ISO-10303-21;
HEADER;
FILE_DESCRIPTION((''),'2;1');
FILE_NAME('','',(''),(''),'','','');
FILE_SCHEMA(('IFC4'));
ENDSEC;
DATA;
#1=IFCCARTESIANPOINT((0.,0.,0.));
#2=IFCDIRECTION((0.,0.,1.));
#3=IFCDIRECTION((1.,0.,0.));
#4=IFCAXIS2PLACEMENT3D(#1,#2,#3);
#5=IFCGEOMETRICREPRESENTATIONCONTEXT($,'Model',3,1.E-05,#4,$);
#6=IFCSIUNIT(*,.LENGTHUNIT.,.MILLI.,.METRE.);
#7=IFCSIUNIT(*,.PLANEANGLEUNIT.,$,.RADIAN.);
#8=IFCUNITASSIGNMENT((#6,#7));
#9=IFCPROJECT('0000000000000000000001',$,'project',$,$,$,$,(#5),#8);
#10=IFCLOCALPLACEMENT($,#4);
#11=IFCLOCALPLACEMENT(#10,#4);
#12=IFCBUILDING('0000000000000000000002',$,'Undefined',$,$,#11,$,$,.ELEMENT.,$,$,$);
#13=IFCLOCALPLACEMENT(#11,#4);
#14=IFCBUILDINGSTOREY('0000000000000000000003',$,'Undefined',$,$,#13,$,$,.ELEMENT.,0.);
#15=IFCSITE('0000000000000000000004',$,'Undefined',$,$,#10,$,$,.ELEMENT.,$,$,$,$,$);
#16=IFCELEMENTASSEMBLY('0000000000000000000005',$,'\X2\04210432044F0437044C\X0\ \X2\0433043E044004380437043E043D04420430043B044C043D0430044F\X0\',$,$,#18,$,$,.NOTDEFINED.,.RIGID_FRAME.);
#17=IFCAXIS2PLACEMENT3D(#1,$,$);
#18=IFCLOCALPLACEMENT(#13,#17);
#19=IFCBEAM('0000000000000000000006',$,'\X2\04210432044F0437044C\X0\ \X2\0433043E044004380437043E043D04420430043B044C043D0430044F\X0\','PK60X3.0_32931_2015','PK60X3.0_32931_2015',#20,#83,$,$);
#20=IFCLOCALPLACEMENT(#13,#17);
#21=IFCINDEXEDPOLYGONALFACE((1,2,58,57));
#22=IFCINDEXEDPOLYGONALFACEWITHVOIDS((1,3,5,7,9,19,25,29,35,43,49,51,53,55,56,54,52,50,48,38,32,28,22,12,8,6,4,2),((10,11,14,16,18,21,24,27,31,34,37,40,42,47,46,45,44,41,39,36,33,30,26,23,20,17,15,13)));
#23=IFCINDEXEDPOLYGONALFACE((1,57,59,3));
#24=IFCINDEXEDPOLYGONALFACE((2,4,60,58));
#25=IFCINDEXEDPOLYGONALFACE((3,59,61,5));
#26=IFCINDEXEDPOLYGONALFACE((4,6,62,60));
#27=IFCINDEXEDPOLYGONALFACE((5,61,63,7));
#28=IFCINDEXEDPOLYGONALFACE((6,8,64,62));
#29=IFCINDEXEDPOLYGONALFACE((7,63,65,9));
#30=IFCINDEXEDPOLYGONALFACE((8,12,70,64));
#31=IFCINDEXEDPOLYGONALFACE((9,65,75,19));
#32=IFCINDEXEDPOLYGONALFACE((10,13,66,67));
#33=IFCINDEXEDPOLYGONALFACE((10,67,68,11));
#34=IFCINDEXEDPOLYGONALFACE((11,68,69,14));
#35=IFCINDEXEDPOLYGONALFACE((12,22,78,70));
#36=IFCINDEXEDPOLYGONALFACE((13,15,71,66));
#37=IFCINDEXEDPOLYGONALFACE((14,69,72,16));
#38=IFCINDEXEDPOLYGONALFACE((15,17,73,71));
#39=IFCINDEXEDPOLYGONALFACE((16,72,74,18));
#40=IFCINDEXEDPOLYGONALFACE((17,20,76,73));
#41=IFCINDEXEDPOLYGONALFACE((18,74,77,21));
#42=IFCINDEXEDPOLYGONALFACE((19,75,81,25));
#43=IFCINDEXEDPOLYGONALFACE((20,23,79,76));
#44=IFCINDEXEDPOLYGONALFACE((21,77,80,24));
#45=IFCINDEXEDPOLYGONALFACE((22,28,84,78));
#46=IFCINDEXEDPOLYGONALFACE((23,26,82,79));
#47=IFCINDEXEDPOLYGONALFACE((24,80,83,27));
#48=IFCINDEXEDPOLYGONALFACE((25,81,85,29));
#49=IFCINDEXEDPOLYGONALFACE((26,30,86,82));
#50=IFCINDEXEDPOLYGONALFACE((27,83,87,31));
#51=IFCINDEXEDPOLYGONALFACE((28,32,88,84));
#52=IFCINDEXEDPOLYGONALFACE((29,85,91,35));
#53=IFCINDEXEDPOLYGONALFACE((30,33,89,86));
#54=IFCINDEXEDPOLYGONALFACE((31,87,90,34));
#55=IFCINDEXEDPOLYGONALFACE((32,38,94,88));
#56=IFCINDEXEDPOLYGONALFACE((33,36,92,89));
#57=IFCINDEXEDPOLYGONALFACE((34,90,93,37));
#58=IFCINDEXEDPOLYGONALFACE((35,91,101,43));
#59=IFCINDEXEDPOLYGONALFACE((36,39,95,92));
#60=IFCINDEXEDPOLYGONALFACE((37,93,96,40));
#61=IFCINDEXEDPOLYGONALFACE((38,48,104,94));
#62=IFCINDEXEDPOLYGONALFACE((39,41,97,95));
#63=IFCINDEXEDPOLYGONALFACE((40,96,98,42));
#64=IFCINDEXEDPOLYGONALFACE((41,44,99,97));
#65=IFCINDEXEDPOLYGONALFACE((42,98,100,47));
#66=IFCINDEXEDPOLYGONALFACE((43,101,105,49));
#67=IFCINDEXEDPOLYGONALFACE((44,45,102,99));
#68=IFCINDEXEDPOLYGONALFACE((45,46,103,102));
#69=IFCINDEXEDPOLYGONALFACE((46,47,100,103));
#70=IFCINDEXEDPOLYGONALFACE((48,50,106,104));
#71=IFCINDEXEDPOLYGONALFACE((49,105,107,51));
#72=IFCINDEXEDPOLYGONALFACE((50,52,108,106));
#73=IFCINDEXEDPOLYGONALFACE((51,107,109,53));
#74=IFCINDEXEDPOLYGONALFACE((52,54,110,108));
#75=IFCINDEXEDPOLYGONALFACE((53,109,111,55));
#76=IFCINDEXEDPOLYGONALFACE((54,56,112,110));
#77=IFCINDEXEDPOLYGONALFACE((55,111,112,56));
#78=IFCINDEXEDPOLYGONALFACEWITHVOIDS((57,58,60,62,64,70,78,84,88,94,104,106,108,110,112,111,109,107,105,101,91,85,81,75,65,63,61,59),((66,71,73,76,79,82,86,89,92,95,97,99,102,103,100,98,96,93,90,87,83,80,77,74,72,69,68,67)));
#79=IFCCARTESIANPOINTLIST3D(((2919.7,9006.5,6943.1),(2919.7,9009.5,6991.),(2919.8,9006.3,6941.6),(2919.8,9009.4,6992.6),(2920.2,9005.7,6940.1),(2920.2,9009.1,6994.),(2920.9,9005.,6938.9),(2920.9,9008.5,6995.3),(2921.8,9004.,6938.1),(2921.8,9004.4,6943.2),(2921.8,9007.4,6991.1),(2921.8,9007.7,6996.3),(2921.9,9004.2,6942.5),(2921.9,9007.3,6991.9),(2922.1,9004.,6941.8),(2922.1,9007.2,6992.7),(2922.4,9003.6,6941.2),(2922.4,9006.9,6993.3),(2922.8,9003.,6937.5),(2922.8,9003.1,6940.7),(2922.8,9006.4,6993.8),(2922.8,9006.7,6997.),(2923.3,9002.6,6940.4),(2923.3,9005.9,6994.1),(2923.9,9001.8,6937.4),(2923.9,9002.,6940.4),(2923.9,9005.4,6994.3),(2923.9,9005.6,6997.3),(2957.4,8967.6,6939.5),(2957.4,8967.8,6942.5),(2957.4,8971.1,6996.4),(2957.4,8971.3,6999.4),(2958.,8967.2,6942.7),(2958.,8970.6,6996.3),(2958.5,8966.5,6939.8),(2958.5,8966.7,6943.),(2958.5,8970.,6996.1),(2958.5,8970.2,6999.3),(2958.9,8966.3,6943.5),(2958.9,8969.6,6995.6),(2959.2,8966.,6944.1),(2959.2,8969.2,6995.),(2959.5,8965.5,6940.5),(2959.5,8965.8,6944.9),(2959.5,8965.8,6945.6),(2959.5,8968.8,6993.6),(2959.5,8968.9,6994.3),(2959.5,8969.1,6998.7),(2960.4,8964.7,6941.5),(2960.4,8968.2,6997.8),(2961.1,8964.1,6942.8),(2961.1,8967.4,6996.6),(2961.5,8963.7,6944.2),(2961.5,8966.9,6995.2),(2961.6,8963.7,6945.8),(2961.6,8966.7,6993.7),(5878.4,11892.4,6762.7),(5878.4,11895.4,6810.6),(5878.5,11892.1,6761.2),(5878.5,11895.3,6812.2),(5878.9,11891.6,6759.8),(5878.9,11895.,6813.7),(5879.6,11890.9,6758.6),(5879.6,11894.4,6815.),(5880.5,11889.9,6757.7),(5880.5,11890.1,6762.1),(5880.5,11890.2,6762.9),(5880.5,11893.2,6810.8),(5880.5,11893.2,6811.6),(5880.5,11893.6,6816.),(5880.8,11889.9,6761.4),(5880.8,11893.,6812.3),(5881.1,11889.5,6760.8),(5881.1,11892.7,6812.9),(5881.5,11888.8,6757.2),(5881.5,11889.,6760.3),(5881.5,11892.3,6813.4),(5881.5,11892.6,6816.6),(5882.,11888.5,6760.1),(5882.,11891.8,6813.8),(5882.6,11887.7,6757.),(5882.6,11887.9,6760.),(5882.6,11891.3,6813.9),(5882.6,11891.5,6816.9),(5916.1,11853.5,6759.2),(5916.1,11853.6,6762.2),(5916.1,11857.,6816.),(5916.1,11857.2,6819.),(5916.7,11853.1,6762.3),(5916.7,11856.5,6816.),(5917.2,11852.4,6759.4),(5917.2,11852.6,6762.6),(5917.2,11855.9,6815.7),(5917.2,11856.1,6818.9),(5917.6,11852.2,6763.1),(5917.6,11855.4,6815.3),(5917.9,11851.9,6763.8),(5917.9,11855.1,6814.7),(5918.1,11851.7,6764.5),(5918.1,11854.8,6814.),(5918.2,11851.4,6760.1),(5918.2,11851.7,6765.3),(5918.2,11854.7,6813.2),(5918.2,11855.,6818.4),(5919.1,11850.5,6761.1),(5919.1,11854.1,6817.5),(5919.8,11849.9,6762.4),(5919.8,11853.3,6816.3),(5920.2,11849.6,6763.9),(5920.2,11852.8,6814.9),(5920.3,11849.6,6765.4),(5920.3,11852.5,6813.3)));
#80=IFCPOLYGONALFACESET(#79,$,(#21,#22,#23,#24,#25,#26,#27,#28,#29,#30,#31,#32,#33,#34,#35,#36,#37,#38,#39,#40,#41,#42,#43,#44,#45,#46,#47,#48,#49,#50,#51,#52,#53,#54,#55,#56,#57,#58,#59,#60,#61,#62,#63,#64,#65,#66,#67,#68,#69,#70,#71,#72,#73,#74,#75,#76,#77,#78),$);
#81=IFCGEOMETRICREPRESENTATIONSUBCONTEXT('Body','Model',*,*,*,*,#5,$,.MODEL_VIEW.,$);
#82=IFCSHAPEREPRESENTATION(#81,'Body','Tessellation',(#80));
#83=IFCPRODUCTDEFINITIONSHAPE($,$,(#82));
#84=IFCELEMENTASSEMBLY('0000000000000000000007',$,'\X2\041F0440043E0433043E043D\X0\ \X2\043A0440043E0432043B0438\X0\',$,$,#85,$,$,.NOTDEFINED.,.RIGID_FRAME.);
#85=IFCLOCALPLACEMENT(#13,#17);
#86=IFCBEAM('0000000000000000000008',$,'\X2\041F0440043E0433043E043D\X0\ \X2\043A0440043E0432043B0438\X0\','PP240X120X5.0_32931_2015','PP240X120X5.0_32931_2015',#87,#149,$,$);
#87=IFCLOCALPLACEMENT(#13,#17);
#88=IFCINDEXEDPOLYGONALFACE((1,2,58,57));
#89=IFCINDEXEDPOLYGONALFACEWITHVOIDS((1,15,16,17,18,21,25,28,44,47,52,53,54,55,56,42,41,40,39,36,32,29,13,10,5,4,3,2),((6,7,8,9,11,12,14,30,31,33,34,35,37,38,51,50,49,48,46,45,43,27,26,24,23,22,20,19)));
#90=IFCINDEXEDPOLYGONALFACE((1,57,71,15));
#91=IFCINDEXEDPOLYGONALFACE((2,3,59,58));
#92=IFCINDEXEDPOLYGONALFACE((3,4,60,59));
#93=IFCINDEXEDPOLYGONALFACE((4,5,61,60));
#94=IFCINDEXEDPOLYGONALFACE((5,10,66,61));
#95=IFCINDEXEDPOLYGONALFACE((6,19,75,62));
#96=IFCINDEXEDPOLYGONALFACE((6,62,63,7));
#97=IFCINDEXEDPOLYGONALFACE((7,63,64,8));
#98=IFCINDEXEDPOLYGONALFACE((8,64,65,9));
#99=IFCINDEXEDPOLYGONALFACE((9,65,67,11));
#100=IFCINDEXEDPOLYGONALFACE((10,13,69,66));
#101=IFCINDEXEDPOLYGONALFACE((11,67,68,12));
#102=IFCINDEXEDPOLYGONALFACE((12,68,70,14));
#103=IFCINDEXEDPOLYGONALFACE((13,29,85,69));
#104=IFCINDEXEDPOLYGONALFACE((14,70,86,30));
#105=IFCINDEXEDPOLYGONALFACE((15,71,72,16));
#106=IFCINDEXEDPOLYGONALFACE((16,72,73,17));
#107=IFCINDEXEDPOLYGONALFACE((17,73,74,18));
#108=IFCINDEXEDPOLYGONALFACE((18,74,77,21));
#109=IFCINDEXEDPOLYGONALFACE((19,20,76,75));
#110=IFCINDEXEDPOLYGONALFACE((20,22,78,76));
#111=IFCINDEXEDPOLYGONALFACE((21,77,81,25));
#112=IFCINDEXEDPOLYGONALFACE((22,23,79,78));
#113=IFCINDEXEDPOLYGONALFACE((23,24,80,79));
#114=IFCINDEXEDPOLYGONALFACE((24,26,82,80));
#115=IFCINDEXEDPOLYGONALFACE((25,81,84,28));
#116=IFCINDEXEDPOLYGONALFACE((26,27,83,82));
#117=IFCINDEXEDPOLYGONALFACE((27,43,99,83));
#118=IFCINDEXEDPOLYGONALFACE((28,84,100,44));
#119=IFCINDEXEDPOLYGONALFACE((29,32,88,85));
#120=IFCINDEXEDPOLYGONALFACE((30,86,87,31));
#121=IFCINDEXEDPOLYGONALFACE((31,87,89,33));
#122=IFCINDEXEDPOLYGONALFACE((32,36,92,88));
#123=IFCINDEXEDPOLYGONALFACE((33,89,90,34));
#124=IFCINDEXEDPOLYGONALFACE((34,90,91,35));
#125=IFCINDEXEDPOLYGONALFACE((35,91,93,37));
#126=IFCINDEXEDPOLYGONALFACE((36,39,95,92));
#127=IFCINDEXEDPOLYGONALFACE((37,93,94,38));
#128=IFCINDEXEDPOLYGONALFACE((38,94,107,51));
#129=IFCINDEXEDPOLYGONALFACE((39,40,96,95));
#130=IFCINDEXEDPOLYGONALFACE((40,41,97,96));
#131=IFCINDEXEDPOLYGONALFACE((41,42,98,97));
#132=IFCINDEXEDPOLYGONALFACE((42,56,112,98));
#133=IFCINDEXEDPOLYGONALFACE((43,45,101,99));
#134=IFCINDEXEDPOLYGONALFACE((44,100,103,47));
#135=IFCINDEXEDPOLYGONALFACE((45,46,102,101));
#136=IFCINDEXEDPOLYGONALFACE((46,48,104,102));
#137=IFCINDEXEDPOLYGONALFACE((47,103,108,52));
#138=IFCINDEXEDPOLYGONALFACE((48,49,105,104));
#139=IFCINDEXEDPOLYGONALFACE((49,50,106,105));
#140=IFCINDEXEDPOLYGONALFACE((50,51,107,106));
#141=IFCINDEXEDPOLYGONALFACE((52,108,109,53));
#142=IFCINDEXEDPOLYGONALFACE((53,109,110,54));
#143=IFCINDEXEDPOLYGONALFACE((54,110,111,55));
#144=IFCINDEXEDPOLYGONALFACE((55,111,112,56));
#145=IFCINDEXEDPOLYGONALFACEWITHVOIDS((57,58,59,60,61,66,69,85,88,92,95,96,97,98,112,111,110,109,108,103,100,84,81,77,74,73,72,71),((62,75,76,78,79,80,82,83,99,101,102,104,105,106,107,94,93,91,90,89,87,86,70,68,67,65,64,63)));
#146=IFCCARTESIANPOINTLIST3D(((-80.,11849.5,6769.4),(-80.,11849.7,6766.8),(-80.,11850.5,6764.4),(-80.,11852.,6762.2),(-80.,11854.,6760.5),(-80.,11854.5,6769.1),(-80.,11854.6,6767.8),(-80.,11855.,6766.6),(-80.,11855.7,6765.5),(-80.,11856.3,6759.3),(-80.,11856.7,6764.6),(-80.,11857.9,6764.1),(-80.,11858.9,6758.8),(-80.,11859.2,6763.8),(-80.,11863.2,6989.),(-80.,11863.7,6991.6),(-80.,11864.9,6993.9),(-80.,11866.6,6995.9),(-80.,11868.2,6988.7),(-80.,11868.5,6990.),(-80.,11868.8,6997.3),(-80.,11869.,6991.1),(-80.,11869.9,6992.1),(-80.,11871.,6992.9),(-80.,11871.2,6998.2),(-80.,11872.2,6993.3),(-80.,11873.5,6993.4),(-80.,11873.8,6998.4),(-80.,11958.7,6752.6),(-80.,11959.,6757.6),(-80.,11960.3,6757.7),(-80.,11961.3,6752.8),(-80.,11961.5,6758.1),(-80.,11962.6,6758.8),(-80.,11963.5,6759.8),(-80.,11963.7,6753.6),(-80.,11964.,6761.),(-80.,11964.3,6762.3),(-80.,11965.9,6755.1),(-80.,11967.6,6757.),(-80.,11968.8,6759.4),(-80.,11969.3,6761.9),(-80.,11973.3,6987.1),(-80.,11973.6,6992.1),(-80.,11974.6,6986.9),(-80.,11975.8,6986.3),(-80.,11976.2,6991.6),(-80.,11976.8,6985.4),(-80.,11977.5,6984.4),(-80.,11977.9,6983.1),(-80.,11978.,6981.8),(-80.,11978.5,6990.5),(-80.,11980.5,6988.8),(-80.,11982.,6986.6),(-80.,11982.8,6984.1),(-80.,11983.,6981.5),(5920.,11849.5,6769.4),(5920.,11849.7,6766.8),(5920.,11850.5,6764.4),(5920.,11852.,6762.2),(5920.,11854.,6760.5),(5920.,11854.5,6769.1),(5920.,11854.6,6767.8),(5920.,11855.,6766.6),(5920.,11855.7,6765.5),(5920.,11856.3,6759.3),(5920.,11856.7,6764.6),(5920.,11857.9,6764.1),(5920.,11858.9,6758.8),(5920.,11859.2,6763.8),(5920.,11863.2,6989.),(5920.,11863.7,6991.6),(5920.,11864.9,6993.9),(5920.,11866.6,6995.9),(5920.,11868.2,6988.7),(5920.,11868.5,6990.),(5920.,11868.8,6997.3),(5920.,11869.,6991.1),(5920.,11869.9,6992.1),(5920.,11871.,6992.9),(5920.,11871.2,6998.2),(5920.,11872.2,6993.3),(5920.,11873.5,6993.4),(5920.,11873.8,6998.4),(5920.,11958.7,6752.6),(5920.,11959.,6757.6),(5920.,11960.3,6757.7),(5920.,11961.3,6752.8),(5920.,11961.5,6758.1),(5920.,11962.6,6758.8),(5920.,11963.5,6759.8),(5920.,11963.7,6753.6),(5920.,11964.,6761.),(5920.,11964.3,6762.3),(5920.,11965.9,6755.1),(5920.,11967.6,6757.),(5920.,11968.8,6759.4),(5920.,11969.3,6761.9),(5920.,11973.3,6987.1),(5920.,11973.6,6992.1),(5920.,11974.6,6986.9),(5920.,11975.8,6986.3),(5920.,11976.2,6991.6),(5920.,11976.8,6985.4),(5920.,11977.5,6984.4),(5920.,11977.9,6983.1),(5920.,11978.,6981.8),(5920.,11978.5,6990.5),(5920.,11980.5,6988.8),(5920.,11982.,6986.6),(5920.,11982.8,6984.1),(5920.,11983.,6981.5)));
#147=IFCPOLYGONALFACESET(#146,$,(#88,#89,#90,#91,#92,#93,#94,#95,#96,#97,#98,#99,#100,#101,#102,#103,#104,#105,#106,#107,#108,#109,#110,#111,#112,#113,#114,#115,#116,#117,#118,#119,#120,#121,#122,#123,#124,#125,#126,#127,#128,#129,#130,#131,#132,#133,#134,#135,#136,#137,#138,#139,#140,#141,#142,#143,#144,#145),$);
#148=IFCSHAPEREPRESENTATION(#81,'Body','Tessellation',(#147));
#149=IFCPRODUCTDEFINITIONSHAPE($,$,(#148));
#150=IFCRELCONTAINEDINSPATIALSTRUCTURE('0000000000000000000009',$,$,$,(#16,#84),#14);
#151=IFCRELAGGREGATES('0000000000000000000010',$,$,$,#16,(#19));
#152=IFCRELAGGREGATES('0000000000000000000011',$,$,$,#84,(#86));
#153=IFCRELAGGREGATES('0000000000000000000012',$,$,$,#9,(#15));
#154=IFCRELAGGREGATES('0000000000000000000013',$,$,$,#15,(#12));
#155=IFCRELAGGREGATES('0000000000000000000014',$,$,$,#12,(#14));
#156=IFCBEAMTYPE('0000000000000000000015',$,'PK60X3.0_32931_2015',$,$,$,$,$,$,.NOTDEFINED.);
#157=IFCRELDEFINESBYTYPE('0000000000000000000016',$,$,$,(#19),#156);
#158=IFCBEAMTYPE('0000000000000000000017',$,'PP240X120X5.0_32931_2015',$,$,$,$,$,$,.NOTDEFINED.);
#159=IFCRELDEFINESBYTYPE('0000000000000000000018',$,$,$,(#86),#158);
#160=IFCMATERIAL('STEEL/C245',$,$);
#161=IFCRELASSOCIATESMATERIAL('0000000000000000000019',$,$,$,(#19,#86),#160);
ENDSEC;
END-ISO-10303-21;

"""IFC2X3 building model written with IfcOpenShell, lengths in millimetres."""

from ifc_helpers import new_model, si_unit, frame, origin_with_axes, origin_2d_with_axis, place, context, subcontext, project, spatial, hollow_rectangle, extrude, material, type_object, element, aggregate, save


model = new_model("IFC2X3")

# Units and contexts
model_context = context("Model", 3, precision=1e-05, world=origin_with_axes())
body_context = subcontext(model_context, "Body", "Model", "MODEL_VIEW")
ifc_project = project(units=[si_unit("LENGTHUNIT", "METRE", prefix="MILLI"), si_unit("PLANEANGLEUNIT", "RADIAN")], contexts=[model_context])

# Site, building, storey
site_placement = place(None, origin_with_axes())
site = spatial("IfcSite", under=ifc_project, at=site_placement, Name="Undefined", CompositionType="ELEMENT")
building_placement = place(site_placement, origin_with_axes())
building = spatial("IfcBuilding", under=site, at=building_placement, Name="Undefined", CompositionType="ELEMENT")
storey_placement = place(building_placement, origin_with_axes())
storey = spatial("IfcBuildingStorey", under=building, at=storey_placement, Name="Undefined", CompositionType="ELEMENT", Elevation=0.0)

# Shared definitions
ifc_material = material(Name="STEEL/C245")

# Element assemblies, beams
beam_type_1 = type_object("IfcBeamType", Name="PK60X3.0_32931_2015", PredefinedType="NOTDEFINED")
assembly_1_placement = place(storey_placement, origin_with_axes())
assembly_1 = element("IfcElementAssembly", 1, at=assembly_1_placement, inside=storey, Name="Связь горизонтальная", AssemblyPlace="NOTDEFINED", PredefinedType="RIGID_FRAME")
beam_1_placement = place(assembly_1_placement, frame((5899.3, 11872.5, 6788.0), z_axis=(0.0, 0.062378, 0.998053), x_axis=(-0.715179, -0.69758, 0.043599)))
beam_1 = element("IfcBeam", 2, at=beam_1_placement, type_object=beam_type_1, material=ifc_material, Name="Связь горизонтальная", Description="PK60X3.0_32931_2015", ObjectType="PK60X3.0_32931_2015", context=body_context, shape_type="SweptSolid", body=[
    extrude(hollow_rectangle(XDim=60.0, YDim=60.0, WallThickness=3.0, InnerFilletRadius=3.0, OuterFilletRadius=6.0, at=origin_2d_with_axis()), frame((4137.0, 0.0, 0.0), z_axis=(-1.0, 0.0, 0.0), x_axis=(0.0, -1.0, 0.0)), (0.0, 0.0, 1.0), 4137.0),
])
aggregate(assembly_1, [beam_1])
assembly_2_placement = place(storey_placement, origin_with_axes())
assembly_2 = element("IfcElementAssembly", 3, at=assembly_2_placement, inside=storey, Name="Прогон кровли", AssemblyPlace="NOTDEFINED", PredefinedType="RIGID_FRAME")
beam_type_2 = type_object("IfcBeamType", Name="PP240X120X5.0_32931_2015", PredefinedType="NOTDEFINED")
beam_2_placement = place(assembly_2_placement, frame((5920.0, 11916.2, 6875.5), z_axis=(0.0, 0.062378, 0.998053), x_axis=(-1.0, 0.0, 0.0)))
beam_2 = element("IfcBeam", 4, at=beam_2_placement, type_object=beam_type_2, material=ifc_material, Name="Прогон кровли", Description="PP240X120X5.0_32931_2015", ObjectType="PP240X120X5.0_32931_2015", context=body_context, shape_type="SweptSolid", body=[
    extrude(hollow_rectangle(XDim=120.0, YDim=240.0, WallThickness=5.0, InnerFilletRadius=5.0, OuterFilletRadius=10.0, at=origin_2d_with_axis()), frame((6000.0, 0.0, 0.0), z_axis=(-1.0, 0.0, 0.0), x_axis=(0.0, -1.0, 0.0)), (0.0, 0.0, 1.0), 6000.0),
])
aggregate(assembly_2, [beam_2])

save(model, "model.ifc")
